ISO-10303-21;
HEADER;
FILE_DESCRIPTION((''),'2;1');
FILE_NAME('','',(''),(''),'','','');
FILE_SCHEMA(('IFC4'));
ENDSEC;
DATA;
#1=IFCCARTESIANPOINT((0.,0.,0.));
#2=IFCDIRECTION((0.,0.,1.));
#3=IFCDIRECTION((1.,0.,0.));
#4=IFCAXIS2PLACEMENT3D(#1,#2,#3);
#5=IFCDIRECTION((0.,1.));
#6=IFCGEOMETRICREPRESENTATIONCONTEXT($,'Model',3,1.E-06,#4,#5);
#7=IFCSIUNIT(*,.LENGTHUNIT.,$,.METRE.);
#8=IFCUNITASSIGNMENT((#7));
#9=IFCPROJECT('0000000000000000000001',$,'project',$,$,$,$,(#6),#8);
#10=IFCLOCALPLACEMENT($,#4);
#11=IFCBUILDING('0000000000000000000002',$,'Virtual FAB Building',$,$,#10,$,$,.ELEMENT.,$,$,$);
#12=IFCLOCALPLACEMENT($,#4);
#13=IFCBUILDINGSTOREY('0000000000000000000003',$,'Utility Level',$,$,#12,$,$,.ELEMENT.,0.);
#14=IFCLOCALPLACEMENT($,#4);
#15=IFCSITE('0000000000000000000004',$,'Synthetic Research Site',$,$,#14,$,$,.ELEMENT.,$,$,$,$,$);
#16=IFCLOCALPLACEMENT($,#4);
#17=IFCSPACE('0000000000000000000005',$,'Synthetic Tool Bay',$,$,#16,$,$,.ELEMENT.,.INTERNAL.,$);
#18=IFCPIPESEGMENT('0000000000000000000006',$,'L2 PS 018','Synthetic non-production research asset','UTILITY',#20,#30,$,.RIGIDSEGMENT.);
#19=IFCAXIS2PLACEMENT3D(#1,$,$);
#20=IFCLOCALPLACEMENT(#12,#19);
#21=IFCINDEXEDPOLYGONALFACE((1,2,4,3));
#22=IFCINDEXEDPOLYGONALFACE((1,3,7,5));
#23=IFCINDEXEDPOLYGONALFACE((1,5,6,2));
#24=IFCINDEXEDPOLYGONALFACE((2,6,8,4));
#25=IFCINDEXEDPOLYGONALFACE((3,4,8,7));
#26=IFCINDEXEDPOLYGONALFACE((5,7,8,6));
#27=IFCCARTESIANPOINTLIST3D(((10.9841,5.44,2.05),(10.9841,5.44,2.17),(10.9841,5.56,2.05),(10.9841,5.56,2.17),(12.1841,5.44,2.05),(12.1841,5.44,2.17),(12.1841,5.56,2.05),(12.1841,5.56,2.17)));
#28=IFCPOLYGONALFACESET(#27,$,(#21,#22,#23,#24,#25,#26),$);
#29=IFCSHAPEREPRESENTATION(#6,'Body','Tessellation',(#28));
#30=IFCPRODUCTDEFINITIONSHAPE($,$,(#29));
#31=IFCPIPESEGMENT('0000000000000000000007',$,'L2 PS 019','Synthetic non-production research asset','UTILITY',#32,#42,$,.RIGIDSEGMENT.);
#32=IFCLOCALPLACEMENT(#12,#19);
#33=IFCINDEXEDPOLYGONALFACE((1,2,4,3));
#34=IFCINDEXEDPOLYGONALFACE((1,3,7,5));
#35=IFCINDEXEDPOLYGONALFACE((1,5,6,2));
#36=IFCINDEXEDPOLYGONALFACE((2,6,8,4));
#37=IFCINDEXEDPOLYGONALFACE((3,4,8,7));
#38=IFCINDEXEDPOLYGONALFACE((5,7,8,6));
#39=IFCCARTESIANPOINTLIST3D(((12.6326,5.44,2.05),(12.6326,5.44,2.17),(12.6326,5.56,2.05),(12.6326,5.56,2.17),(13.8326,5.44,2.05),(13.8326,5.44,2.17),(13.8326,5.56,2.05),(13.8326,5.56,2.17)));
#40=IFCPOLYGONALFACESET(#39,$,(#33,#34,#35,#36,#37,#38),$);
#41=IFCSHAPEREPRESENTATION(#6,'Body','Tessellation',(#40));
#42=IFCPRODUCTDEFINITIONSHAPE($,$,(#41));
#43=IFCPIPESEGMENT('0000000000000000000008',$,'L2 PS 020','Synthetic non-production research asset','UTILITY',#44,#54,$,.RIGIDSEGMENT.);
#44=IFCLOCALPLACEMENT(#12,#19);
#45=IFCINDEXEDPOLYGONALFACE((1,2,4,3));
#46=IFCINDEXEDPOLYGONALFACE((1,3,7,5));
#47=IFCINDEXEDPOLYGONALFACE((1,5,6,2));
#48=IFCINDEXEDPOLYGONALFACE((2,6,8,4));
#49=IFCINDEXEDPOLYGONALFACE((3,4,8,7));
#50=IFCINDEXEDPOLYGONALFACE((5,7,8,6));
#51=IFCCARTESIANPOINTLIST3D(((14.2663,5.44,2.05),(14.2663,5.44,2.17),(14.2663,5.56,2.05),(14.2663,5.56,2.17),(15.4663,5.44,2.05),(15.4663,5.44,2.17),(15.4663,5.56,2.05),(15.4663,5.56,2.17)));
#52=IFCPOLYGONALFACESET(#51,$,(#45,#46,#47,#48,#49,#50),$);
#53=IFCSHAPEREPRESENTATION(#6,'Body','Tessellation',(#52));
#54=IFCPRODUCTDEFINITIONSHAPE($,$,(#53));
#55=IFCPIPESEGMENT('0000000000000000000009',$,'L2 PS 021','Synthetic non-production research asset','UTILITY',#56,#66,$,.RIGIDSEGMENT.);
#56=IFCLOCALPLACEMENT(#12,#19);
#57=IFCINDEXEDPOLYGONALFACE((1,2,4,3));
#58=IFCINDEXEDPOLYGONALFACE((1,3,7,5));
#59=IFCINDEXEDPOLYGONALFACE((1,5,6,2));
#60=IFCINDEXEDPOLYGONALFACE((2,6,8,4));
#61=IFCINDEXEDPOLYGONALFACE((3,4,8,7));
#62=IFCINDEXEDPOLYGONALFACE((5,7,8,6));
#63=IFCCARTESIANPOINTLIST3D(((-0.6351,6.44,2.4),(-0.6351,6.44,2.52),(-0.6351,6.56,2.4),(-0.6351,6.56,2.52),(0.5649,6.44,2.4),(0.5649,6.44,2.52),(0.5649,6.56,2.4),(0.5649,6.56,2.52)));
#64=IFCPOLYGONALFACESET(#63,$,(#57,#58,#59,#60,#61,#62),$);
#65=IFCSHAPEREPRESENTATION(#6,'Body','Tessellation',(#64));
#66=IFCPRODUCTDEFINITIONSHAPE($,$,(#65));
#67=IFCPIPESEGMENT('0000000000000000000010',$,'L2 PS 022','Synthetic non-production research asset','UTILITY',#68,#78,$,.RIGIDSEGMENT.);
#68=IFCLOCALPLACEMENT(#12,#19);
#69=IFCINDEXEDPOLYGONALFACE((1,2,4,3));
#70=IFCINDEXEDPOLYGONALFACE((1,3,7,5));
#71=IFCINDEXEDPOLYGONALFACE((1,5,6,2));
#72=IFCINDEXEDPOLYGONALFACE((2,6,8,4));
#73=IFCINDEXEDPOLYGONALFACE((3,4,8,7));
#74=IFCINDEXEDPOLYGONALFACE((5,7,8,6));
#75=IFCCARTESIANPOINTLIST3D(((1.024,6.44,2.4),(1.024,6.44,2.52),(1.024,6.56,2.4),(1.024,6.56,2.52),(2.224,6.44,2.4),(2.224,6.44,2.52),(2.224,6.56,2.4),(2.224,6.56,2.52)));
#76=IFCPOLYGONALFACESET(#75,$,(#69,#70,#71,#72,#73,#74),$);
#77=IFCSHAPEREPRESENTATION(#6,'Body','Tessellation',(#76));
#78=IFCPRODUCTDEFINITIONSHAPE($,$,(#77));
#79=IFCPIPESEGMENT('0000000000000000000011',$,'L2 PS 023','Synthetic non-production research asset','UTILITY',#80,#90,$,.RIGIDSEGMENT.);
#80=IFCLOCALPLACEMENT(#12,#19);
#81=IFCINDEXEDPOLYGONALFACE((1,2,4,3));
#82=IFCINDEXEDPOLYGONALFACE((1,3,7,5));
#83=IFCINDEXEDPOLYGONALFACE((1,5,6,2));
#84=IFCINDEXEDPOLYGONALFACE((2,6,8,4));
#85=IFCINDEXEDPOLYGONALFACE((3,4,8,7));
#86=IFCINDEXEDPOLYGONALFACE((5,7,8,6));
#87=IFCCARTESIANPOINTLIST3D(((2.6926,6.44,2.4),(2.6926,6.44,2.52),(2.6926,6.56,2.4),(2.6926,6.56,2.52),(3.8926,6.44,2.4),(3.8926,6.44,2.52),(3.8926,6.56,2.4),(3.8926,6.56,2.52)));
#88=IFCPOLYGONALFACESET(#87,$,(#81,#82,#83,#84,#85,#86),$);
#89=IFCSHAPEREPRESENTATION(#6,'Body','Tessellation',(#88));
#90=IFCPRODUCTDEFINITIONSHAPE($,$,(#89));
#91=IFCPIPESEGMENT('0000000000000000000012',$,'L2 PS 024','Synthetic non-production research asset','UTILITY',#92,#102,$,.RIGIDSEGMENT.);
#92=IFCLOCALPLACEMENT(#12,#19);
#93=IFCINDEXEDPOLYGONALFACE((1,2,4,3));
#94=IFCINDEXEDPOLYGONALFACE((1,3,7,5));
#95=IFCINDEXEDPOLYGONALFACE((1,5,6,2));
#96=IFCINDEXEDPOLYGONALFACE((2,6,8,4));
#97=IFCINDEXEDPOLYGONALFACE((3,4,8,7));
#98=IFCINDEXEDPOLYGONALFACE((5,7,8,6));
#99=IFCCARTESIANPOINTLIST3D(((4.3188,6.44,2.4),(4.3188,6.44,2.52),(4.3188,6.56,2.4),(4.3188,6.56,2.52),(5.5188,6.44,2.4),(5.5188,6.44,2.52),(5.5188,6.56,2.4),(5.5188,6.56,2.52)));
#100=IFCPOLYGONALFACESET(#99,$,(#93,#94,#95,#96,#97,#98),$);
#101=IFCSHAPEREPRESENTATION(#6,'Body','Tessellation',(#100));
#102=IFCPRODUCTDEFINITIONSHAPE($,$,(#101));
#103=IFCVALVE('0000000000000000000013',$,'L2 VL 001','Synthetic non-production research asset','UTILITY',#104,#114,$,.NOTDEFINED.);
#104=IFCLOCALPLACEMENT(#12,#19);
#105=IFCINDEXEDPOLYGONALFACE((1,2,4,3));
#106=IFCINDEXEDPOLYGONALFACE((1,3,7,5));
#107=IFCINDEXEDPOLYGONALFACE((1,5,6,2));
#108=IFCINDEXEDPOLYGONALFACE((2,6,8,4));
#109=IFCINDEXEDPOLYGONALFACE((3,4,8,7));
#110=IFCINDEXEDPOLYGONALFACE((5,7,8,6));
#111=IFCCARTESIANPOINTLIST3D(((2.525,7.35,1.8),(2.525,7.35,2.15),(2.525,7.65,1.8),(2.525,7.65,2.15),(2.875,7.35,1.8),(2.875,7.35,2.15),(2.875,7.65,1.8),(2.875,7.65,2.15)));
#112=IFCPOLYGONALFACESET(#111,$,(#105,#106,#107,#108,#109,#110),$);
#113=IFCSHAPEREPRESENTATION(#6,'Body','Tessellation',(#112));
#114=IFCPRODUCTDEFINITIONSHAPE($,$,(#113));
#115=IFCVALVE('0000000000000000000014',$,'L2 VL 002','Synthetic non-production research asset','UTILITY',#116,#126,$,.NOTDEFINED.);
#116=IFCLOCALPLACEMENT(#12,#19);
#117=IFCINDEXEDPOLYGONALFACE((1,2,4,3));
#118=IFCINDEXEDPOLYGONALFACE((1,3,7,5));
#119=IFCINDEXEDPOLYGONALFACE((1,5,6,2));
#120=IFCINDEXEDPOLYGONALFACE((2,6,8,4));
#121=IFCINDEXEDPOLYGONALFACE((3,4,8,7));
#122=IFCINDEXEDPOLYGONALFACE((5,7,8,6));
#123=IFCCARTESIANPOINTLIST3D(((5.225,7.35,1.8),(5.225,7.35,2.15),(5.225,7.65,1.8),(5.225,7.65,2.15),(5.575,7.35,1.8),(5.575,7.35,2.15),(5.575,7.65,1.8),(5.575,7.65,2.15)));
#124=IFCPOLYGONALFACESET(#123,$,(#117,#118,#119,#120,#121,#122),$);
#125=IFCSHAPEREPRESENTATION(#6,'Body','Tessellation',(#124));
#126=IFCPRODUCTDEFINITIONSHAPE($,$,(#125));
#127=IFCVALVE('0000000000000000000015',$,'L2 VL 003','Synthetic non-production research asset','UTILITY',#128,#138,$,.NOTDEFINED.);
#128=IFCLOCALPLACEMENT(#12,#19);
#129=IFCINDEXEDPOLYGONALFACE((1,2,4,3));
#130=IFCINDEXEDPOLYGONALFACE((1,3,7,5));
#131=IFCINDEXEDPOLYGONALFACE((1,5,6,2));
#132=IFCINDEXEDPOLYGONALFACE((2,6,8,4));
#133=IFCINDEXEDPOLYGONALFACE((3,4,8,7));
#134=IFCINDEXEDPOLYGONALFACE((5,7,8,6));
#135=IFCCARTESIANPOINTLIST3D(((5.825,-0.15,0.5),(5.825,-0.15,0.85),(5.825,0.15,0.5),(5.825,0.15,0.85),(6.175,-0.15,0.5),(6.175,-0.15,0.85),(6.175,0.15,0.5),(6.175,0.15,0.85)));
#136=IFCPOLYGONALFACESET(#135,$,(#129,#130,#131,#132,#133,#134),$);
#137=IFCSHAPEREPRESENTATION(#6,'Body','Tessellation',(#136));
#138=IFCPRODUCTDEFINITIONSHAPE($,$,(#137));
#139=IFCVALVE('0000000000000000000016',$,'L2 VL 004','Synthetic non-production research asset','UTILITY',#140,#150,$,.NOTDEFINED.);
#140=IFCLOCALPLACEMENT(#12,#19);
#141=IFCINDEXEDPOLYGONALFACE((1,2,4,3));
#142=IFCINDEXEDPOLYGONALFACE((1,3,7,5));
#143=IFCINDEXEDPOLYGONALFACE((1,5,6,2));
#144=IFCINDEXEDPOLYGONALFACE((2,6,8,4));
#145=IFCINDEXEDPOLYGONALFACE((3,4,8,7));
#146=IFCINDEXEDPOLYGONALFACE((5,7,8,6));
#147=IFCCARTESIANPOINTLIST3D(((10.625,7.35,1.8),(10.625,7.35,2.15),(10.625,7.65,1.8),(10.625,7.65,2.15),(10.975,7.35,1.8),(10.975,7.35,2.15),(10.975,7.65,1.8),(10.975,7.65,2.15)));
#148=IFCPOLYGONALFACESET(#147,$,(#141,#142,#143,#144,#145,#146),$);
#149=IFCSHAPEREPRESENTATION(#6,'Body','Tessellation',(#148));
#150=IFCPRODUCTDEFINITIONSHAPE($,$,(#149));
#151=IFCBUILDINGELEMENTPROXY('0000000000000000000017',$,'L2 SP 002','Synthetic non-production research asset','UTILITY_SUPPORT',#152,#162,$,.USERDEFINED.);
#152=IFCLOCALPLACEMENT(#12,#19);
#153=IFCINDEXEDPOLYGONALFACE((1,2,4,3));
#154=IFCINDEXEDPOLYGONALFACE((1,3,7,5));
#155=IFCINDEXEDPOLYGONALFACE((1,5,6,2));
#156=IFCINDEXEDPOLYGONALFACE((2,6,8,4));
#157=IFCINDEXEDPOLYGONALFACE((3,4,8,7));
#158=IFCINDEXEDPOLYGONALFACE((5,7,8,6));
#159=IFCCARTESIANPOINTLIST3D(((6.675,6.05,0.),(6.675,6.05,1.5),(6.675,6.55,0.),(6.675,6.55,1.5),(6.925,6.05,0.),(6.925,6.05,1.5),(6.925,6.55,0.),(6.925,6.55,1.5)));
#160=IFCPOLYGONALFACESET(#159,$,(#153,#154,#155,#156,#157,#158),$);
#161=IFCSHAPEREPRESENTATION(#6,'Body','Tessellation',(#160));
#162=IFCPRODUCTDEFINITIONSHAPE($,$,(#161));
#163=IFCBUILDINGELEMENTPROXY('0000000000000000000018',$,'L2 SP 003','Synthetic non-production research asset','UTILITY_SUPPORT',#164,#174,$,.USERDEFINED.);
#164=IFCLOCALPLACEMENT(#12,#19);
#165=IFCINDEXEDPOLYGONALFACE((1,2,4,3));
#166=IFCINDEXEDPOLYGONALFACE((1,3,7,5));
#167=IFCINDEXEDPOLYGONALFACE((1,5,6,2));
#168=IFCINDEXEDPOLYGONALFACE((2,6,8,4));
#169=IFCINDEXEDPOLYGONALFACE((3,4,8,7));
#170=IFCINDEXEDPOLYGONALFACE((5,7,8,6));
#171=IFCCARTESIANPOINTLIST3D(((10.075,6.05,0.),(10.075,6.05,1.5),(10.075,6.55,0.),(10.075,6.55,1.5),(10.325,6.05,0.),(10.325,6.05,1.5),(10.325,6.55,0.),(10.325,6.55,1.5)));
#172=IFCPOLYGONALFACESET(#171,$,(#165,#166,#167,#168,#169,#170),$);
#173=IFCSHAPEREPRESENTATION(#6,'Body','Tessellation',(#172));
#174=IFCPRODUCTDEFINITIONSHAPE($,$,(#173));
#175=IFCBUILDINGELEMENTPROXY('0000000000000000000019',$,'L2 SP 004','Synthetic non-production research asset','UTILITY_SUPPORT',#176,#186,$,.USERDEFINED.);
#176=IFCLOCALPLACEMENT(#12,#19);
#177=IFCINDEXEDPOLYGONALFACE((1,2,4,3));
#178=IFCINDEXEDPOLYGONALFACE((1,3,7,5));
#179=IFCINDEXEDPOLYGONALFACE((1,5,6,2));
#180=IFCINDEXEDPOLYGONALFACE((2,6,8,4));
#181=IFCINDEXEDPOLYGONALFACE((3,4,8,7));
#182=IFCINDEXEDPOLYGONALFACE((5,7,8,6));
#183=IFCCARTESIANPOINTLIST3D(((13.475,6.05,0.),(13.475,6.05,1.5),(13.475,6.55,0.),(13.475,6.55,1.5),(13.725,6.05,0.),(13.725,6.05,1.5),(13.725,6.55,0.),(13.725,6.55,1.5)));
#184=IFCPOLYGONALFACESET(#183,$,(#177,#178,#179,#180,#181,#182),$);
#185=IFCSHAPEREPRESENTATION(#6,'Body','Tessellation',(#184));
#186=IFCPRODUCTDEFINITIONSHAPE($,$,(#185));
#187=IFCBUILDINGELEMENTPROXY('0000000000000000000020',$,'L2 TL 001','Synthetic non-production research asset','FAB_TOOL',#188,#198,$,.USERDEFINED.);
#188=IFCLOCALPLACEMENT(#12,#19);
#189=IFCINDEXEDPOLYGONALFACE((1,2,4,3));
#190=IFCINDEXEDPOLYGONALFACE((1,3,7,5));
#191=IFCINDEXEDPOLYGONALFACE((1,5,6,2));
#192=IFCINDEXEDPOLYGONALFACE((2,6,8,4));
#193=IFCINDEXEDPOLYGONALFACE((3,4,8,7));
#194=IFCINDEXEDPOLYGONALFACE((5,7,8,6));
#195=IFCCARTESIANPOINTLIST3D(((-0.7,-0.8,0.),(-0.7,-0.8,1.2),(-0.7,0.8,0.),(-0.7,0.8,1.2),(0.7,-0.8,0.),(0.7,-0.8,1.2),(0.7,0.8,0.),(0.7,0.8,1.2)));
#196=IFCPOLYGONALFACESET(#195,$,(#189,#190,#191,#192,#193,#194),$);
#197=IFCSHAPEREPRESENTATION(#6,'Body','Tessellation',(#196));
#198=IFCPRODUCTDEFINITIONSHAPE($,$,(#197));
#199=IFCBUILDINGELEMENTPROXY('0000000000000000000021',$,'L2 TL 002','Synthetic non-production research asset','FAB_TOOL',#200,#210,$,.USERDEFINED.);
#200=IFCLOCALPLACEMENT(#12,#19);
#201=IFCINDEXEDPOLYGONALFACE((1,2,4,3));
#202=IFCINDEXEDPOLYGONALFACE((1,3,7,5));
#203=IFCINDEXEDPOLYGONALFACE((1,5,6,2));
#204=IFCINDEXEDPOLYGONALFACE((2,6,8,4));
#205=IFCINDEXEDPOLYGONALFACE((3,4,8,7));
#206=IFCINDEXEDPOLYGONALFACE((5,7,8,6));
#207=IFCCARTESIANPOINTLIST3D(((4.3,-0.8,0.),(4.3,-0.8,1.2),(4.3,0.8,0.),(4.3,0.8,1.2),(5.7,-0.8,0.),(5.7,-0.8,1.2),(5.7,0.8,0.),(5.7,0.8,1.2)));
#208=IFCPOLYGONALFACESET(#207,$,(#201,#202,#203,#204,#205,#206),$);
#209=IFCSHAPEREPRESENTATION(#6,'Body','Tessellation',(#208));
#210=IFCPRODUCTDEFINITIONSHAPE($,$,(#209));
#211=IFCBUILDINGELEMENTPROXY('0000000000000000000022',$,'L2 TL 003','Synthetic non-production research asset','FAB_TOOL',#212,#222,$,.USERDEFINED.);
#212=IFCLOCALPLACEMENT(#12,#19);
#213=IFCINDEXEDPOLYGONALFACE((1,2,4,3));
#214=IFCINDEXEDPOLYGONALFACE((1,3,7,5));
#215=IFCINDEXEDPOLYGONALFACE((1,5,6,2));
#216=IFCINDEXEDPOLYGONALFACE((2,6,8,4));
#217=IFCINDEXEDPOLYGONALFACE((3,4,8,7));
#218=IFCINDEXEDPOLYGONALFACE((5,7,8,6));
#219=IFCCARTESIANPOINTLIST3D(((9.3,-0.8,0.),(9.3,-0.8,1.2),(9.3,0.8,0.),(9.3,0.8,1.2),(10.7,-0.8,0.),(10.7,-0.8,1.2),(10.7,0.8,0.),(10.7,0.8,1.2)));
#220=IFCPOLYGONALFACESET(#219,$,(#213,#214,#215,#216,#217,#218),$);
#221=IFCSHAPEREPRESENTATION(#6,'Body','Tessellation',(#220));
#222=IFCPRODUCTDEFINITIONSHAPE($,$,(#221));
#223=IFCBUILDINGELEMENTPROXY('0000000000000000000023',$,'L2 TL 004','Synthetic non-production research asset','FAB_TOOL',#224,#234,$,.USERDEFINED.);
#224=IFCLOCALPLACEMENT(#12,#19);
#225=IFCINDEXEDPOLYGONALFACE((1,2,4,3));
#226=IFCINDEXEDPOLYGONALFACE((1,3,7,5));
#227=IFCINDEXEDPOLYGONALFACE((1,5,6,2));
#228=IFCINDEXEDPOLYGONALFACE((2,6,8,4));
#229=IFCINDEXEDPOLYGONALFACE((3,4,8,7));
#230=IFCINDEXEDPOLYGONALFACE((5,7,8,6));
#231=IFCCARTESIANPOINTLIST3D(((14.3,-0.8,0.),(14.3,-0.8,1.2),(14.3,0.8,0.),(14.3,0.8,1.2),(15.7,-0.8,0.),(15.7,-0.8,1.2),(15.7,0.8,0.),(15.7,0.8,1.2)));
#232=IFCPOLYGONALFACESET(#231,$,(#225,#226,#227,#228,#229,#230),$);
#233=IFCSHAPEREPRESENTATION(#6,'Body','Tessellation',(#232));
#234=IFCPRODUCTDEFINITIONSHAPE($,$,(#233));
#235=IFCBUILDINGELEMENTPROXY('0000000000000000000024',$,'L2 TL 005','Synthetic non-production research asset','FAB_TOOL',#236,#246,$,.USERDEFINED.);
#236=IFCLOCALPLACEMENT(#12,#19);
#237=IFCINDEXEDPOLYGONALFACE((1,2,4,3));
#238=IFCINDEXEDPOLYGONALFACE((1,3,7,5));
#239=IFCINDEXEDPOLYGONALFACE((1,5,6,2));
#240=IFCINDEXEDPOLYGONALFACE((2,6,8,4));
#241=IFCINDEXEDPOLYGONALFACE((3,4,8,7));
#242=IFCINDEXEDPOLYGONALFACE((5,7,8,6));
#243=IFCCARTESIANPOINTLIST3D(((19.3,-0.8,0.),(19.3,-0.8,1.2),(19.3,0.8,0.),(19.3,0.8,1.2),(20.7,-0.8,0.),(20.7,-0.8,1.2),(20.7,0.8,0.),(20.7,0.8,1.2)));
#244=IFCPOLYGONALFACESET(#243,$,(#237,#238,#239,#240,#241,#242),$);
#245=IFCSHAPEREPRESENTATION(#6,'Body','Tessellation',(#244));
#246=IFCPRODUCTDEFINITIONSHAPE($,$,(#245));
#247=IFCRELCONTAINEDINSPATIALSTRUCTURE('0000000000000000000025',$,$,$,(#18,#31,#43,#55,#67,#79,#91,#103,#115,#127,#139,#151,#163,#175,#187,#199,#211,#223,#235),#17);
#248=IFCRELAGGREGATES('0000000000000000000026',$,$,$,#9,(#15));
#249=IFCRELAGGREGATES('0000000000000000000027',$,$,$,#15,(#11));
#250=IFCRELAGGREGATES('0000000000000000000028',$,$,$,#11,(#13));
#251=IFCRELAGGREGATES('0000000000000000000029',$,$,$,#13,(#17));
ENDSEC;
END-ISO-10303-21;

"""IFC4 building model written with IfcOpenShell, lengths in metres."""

from ifc_helpers import new_model, si_unit, direction, frame, origin_with_axes, origin_2d_with_axis, place, context, project, spatial, rectangle, extrude, element, save


model = new_model("IFC4")

# Units and contexts
model_context = context("Model", 3, precision=1e-06, world=origin_with_axes(), true_north=direction((0.0, 1.0)))
ifc_project = project(units=[si_unit("LENGTHUNIT", "METRE")], contexts=[model_context])

# Site, building, storey, space
site_placement = place(None, origin_with_axes())
site = spatial("IfcSite", under=ifc_project, at=site_placement, Name="Synthetic Research Site", CompositionType="ELEMENT")
building_placement = place(None, origin_with_axes())
building = spatial("IfcBuilding", under=site, at=building_placement, Name="Virtual FAB Building", CompositionType="ELEMENT")
storey_placement = place(None, origin_with_axes())
storey = spatial("IfcBuildingStorey", under=building, at=storey_placement, Name="Utility Level", CompositionType="ELEMENT", Elevation=0.0)
space_placement = place(None, origin_with_axes())
space = spatial("IfcSpace", under=storey, at=space_placement, Name="Synthetic Tool Bay", CompositionType="ELEMENT", PredefinedType="INTERNAL")

# Pipe segments
for number, where, z_axis, x_axis, name in (
    (1, (11.5841, 5.5, 2.05), (0.0, 0.0, 1.0), (1.0, 0.0, 0.0), "L2 PS 018"),
    (2, (13.2326, 5.5, 2.05), (0.0, 0.0, 1.0), (1.0, 0.0, 0.0), "L2 PS 019"),
    (3, (14.8663, 5.5, 2.05), (0.0, 0.0, 1.0), (1.0, 0.0, 0.0), "L2 PS 020"),
    (4, (-0.0351, 6.5, 2.4), (0.0, 0.0, 1.0), (1.0, 0.0, 0.0), "L2 PS 021"),
    (5, (1.624, 6.5, 2.4), (0.0, 0.0, 1.0), (1.0, 0.0, 0.0), "L2 PS 022"),
    (6, (3.2926, 6.5, 2.4), (0.0, 0.0, 1.0), (1.0, 0.0, 0.0), "L2 PS 023"),
    (7, (4.9188, 6.5, 2.4), (0.0, 0.0, 1.0), (1.0, 0.0, 0.0), "L2 PS 024"),
):
    element("IfcPipeSegment", number, at=place(None, frame(where, z_axis=z_axis, x_axis=x_axis)), inside=space, Name=name, Description="Synthetic non-production research asset", ObjectType="UTILITY", PredefinedType="RIGIDSEGMENT", context=model_context, shape_type="SweptSolid", body=[
        extrude(rectangle(XDim=1.2, YDim=0.12, at=origin_2d_with_axis()), origin_with_axes(), (0.0, 0.0, 1.0), 0.12),
    ])

# Valves
for number, where, z_axis, x_axis, name in (
    (8, (2.7, 7.5, 1.8), (0.0, 0.0, 1.0), (1.0, 0.0, 0.0), "L2 VL 001"),
    (9, (5.4, 7.5, 1.8), (0.0, 0.0, 1.0), (1.0, 0.0, 0.0), "L2 VL 002"),
    (10, (6.0, 0.0, 0.5), (0.0, 0.0, 1.0), (1.0, 0.0, 0.0), "L2 VL 003"),
    (11, (10.8, 7.5, 1.8), (0.0, 0.0, 1.0), (1.0, 0.0, 0.0), "L2 VL 004"),
):
    element("IfcValve", number, at=place(None, frame(where, z_axis=z_axis, x_axis=x_axis)), inside=space, Name=name, Description="Synthetic non-production research asset", ObjectType="UTILITY", PredefinedType="NOTDEFINED", context=model_context, shape_type="SweptSolid", body=[
        extrude(rectangle(XDim=0.35, YDim=0.3, at=origin_2d_with_axis()), origin_with_axes(), (0.0, 0.0, 1.0), 0.35),
    ])

# Building element proxies
for number, where, z_axis, x_axis, name in (
    (12, (6.8, 6.3, 0.0), (0.0, 0.0, 1.0), (1.0, 0.0, 0.0), "L2 SP 002"),
    (13, (10.2, 6.3, 0.0), (0.0, 0.0, 1.0), (1.0, 0.0, 0.0), "L2 SP 003"),
    (14, (13.6, 6.3, 0.0), (0.0, 0.0, 1.0), (1.0, 0.0, 0.0), "L2 SP 004"),
):
    element("IfcBuildingElementProxy", number, at=place(None, frame(where, z_axis=z_axis, x_axis=x_axis)), inside=space, Name=name, Description="Synthetic non-production research asset", ObjectType="UTILITY_SUPPORT", PredefinedType="USERDEFINED", context=model_context, shape_type="SweptSolid", body=[
        extrude(rectangle(XDim=0.25, YDim=0.5, at=origin_2d_with_axis()), origin_with_axes(), (0.0, 0.0, 1.0), 1.5),
    ])
for number, where, z_axis, x_axis, name in (
    (15, (0.0, 0.0, 0.0), (0.0, 0.0, 1.0), (1.0, 0.0, 0.0), "L2 TL 001"),
    (16, (5.0, 0.0, 0.0), (0.0, 0.0, 1.0), (1.0, 0.0, 0.0), "L2 TL 002"),
    (17, (10.0, 0.0, 0.0), (0.0, 0.0, 1.0), (1.0, 0.0, 0.0), "L2 TL 003"),
    (18, (15.0, 0.0, 0.0), (0.0, 0.0, 1.0), (1.0, 0.0, 0.0), "L2 TL 004"),
    (19, (20.0, 0.0, 0.0), (0.0, 0.0, 1.0), (1.0, 0.0, 0.0), "L2 TL 005"),
):
    element("IfcBuildingElementProxy", number, at=place(None, frame(where, z_axis=z_axis, x_axis=x_axis)), inside=space, Name=name, Description="Synthetic non-production research asset", ObjectType="FAB_TOOL", PredefinedType="USERDEFINED", context=model_context, shape_type="SweptSolid", body=[
        extrude(rectangle(XDim=1.4, YDim=1.6, at=origin_2d_with_axis()), origin_with_axes(), (0.0, 0.0, 1.0), 1.2),
    ])

save(model, "model.ifc")
